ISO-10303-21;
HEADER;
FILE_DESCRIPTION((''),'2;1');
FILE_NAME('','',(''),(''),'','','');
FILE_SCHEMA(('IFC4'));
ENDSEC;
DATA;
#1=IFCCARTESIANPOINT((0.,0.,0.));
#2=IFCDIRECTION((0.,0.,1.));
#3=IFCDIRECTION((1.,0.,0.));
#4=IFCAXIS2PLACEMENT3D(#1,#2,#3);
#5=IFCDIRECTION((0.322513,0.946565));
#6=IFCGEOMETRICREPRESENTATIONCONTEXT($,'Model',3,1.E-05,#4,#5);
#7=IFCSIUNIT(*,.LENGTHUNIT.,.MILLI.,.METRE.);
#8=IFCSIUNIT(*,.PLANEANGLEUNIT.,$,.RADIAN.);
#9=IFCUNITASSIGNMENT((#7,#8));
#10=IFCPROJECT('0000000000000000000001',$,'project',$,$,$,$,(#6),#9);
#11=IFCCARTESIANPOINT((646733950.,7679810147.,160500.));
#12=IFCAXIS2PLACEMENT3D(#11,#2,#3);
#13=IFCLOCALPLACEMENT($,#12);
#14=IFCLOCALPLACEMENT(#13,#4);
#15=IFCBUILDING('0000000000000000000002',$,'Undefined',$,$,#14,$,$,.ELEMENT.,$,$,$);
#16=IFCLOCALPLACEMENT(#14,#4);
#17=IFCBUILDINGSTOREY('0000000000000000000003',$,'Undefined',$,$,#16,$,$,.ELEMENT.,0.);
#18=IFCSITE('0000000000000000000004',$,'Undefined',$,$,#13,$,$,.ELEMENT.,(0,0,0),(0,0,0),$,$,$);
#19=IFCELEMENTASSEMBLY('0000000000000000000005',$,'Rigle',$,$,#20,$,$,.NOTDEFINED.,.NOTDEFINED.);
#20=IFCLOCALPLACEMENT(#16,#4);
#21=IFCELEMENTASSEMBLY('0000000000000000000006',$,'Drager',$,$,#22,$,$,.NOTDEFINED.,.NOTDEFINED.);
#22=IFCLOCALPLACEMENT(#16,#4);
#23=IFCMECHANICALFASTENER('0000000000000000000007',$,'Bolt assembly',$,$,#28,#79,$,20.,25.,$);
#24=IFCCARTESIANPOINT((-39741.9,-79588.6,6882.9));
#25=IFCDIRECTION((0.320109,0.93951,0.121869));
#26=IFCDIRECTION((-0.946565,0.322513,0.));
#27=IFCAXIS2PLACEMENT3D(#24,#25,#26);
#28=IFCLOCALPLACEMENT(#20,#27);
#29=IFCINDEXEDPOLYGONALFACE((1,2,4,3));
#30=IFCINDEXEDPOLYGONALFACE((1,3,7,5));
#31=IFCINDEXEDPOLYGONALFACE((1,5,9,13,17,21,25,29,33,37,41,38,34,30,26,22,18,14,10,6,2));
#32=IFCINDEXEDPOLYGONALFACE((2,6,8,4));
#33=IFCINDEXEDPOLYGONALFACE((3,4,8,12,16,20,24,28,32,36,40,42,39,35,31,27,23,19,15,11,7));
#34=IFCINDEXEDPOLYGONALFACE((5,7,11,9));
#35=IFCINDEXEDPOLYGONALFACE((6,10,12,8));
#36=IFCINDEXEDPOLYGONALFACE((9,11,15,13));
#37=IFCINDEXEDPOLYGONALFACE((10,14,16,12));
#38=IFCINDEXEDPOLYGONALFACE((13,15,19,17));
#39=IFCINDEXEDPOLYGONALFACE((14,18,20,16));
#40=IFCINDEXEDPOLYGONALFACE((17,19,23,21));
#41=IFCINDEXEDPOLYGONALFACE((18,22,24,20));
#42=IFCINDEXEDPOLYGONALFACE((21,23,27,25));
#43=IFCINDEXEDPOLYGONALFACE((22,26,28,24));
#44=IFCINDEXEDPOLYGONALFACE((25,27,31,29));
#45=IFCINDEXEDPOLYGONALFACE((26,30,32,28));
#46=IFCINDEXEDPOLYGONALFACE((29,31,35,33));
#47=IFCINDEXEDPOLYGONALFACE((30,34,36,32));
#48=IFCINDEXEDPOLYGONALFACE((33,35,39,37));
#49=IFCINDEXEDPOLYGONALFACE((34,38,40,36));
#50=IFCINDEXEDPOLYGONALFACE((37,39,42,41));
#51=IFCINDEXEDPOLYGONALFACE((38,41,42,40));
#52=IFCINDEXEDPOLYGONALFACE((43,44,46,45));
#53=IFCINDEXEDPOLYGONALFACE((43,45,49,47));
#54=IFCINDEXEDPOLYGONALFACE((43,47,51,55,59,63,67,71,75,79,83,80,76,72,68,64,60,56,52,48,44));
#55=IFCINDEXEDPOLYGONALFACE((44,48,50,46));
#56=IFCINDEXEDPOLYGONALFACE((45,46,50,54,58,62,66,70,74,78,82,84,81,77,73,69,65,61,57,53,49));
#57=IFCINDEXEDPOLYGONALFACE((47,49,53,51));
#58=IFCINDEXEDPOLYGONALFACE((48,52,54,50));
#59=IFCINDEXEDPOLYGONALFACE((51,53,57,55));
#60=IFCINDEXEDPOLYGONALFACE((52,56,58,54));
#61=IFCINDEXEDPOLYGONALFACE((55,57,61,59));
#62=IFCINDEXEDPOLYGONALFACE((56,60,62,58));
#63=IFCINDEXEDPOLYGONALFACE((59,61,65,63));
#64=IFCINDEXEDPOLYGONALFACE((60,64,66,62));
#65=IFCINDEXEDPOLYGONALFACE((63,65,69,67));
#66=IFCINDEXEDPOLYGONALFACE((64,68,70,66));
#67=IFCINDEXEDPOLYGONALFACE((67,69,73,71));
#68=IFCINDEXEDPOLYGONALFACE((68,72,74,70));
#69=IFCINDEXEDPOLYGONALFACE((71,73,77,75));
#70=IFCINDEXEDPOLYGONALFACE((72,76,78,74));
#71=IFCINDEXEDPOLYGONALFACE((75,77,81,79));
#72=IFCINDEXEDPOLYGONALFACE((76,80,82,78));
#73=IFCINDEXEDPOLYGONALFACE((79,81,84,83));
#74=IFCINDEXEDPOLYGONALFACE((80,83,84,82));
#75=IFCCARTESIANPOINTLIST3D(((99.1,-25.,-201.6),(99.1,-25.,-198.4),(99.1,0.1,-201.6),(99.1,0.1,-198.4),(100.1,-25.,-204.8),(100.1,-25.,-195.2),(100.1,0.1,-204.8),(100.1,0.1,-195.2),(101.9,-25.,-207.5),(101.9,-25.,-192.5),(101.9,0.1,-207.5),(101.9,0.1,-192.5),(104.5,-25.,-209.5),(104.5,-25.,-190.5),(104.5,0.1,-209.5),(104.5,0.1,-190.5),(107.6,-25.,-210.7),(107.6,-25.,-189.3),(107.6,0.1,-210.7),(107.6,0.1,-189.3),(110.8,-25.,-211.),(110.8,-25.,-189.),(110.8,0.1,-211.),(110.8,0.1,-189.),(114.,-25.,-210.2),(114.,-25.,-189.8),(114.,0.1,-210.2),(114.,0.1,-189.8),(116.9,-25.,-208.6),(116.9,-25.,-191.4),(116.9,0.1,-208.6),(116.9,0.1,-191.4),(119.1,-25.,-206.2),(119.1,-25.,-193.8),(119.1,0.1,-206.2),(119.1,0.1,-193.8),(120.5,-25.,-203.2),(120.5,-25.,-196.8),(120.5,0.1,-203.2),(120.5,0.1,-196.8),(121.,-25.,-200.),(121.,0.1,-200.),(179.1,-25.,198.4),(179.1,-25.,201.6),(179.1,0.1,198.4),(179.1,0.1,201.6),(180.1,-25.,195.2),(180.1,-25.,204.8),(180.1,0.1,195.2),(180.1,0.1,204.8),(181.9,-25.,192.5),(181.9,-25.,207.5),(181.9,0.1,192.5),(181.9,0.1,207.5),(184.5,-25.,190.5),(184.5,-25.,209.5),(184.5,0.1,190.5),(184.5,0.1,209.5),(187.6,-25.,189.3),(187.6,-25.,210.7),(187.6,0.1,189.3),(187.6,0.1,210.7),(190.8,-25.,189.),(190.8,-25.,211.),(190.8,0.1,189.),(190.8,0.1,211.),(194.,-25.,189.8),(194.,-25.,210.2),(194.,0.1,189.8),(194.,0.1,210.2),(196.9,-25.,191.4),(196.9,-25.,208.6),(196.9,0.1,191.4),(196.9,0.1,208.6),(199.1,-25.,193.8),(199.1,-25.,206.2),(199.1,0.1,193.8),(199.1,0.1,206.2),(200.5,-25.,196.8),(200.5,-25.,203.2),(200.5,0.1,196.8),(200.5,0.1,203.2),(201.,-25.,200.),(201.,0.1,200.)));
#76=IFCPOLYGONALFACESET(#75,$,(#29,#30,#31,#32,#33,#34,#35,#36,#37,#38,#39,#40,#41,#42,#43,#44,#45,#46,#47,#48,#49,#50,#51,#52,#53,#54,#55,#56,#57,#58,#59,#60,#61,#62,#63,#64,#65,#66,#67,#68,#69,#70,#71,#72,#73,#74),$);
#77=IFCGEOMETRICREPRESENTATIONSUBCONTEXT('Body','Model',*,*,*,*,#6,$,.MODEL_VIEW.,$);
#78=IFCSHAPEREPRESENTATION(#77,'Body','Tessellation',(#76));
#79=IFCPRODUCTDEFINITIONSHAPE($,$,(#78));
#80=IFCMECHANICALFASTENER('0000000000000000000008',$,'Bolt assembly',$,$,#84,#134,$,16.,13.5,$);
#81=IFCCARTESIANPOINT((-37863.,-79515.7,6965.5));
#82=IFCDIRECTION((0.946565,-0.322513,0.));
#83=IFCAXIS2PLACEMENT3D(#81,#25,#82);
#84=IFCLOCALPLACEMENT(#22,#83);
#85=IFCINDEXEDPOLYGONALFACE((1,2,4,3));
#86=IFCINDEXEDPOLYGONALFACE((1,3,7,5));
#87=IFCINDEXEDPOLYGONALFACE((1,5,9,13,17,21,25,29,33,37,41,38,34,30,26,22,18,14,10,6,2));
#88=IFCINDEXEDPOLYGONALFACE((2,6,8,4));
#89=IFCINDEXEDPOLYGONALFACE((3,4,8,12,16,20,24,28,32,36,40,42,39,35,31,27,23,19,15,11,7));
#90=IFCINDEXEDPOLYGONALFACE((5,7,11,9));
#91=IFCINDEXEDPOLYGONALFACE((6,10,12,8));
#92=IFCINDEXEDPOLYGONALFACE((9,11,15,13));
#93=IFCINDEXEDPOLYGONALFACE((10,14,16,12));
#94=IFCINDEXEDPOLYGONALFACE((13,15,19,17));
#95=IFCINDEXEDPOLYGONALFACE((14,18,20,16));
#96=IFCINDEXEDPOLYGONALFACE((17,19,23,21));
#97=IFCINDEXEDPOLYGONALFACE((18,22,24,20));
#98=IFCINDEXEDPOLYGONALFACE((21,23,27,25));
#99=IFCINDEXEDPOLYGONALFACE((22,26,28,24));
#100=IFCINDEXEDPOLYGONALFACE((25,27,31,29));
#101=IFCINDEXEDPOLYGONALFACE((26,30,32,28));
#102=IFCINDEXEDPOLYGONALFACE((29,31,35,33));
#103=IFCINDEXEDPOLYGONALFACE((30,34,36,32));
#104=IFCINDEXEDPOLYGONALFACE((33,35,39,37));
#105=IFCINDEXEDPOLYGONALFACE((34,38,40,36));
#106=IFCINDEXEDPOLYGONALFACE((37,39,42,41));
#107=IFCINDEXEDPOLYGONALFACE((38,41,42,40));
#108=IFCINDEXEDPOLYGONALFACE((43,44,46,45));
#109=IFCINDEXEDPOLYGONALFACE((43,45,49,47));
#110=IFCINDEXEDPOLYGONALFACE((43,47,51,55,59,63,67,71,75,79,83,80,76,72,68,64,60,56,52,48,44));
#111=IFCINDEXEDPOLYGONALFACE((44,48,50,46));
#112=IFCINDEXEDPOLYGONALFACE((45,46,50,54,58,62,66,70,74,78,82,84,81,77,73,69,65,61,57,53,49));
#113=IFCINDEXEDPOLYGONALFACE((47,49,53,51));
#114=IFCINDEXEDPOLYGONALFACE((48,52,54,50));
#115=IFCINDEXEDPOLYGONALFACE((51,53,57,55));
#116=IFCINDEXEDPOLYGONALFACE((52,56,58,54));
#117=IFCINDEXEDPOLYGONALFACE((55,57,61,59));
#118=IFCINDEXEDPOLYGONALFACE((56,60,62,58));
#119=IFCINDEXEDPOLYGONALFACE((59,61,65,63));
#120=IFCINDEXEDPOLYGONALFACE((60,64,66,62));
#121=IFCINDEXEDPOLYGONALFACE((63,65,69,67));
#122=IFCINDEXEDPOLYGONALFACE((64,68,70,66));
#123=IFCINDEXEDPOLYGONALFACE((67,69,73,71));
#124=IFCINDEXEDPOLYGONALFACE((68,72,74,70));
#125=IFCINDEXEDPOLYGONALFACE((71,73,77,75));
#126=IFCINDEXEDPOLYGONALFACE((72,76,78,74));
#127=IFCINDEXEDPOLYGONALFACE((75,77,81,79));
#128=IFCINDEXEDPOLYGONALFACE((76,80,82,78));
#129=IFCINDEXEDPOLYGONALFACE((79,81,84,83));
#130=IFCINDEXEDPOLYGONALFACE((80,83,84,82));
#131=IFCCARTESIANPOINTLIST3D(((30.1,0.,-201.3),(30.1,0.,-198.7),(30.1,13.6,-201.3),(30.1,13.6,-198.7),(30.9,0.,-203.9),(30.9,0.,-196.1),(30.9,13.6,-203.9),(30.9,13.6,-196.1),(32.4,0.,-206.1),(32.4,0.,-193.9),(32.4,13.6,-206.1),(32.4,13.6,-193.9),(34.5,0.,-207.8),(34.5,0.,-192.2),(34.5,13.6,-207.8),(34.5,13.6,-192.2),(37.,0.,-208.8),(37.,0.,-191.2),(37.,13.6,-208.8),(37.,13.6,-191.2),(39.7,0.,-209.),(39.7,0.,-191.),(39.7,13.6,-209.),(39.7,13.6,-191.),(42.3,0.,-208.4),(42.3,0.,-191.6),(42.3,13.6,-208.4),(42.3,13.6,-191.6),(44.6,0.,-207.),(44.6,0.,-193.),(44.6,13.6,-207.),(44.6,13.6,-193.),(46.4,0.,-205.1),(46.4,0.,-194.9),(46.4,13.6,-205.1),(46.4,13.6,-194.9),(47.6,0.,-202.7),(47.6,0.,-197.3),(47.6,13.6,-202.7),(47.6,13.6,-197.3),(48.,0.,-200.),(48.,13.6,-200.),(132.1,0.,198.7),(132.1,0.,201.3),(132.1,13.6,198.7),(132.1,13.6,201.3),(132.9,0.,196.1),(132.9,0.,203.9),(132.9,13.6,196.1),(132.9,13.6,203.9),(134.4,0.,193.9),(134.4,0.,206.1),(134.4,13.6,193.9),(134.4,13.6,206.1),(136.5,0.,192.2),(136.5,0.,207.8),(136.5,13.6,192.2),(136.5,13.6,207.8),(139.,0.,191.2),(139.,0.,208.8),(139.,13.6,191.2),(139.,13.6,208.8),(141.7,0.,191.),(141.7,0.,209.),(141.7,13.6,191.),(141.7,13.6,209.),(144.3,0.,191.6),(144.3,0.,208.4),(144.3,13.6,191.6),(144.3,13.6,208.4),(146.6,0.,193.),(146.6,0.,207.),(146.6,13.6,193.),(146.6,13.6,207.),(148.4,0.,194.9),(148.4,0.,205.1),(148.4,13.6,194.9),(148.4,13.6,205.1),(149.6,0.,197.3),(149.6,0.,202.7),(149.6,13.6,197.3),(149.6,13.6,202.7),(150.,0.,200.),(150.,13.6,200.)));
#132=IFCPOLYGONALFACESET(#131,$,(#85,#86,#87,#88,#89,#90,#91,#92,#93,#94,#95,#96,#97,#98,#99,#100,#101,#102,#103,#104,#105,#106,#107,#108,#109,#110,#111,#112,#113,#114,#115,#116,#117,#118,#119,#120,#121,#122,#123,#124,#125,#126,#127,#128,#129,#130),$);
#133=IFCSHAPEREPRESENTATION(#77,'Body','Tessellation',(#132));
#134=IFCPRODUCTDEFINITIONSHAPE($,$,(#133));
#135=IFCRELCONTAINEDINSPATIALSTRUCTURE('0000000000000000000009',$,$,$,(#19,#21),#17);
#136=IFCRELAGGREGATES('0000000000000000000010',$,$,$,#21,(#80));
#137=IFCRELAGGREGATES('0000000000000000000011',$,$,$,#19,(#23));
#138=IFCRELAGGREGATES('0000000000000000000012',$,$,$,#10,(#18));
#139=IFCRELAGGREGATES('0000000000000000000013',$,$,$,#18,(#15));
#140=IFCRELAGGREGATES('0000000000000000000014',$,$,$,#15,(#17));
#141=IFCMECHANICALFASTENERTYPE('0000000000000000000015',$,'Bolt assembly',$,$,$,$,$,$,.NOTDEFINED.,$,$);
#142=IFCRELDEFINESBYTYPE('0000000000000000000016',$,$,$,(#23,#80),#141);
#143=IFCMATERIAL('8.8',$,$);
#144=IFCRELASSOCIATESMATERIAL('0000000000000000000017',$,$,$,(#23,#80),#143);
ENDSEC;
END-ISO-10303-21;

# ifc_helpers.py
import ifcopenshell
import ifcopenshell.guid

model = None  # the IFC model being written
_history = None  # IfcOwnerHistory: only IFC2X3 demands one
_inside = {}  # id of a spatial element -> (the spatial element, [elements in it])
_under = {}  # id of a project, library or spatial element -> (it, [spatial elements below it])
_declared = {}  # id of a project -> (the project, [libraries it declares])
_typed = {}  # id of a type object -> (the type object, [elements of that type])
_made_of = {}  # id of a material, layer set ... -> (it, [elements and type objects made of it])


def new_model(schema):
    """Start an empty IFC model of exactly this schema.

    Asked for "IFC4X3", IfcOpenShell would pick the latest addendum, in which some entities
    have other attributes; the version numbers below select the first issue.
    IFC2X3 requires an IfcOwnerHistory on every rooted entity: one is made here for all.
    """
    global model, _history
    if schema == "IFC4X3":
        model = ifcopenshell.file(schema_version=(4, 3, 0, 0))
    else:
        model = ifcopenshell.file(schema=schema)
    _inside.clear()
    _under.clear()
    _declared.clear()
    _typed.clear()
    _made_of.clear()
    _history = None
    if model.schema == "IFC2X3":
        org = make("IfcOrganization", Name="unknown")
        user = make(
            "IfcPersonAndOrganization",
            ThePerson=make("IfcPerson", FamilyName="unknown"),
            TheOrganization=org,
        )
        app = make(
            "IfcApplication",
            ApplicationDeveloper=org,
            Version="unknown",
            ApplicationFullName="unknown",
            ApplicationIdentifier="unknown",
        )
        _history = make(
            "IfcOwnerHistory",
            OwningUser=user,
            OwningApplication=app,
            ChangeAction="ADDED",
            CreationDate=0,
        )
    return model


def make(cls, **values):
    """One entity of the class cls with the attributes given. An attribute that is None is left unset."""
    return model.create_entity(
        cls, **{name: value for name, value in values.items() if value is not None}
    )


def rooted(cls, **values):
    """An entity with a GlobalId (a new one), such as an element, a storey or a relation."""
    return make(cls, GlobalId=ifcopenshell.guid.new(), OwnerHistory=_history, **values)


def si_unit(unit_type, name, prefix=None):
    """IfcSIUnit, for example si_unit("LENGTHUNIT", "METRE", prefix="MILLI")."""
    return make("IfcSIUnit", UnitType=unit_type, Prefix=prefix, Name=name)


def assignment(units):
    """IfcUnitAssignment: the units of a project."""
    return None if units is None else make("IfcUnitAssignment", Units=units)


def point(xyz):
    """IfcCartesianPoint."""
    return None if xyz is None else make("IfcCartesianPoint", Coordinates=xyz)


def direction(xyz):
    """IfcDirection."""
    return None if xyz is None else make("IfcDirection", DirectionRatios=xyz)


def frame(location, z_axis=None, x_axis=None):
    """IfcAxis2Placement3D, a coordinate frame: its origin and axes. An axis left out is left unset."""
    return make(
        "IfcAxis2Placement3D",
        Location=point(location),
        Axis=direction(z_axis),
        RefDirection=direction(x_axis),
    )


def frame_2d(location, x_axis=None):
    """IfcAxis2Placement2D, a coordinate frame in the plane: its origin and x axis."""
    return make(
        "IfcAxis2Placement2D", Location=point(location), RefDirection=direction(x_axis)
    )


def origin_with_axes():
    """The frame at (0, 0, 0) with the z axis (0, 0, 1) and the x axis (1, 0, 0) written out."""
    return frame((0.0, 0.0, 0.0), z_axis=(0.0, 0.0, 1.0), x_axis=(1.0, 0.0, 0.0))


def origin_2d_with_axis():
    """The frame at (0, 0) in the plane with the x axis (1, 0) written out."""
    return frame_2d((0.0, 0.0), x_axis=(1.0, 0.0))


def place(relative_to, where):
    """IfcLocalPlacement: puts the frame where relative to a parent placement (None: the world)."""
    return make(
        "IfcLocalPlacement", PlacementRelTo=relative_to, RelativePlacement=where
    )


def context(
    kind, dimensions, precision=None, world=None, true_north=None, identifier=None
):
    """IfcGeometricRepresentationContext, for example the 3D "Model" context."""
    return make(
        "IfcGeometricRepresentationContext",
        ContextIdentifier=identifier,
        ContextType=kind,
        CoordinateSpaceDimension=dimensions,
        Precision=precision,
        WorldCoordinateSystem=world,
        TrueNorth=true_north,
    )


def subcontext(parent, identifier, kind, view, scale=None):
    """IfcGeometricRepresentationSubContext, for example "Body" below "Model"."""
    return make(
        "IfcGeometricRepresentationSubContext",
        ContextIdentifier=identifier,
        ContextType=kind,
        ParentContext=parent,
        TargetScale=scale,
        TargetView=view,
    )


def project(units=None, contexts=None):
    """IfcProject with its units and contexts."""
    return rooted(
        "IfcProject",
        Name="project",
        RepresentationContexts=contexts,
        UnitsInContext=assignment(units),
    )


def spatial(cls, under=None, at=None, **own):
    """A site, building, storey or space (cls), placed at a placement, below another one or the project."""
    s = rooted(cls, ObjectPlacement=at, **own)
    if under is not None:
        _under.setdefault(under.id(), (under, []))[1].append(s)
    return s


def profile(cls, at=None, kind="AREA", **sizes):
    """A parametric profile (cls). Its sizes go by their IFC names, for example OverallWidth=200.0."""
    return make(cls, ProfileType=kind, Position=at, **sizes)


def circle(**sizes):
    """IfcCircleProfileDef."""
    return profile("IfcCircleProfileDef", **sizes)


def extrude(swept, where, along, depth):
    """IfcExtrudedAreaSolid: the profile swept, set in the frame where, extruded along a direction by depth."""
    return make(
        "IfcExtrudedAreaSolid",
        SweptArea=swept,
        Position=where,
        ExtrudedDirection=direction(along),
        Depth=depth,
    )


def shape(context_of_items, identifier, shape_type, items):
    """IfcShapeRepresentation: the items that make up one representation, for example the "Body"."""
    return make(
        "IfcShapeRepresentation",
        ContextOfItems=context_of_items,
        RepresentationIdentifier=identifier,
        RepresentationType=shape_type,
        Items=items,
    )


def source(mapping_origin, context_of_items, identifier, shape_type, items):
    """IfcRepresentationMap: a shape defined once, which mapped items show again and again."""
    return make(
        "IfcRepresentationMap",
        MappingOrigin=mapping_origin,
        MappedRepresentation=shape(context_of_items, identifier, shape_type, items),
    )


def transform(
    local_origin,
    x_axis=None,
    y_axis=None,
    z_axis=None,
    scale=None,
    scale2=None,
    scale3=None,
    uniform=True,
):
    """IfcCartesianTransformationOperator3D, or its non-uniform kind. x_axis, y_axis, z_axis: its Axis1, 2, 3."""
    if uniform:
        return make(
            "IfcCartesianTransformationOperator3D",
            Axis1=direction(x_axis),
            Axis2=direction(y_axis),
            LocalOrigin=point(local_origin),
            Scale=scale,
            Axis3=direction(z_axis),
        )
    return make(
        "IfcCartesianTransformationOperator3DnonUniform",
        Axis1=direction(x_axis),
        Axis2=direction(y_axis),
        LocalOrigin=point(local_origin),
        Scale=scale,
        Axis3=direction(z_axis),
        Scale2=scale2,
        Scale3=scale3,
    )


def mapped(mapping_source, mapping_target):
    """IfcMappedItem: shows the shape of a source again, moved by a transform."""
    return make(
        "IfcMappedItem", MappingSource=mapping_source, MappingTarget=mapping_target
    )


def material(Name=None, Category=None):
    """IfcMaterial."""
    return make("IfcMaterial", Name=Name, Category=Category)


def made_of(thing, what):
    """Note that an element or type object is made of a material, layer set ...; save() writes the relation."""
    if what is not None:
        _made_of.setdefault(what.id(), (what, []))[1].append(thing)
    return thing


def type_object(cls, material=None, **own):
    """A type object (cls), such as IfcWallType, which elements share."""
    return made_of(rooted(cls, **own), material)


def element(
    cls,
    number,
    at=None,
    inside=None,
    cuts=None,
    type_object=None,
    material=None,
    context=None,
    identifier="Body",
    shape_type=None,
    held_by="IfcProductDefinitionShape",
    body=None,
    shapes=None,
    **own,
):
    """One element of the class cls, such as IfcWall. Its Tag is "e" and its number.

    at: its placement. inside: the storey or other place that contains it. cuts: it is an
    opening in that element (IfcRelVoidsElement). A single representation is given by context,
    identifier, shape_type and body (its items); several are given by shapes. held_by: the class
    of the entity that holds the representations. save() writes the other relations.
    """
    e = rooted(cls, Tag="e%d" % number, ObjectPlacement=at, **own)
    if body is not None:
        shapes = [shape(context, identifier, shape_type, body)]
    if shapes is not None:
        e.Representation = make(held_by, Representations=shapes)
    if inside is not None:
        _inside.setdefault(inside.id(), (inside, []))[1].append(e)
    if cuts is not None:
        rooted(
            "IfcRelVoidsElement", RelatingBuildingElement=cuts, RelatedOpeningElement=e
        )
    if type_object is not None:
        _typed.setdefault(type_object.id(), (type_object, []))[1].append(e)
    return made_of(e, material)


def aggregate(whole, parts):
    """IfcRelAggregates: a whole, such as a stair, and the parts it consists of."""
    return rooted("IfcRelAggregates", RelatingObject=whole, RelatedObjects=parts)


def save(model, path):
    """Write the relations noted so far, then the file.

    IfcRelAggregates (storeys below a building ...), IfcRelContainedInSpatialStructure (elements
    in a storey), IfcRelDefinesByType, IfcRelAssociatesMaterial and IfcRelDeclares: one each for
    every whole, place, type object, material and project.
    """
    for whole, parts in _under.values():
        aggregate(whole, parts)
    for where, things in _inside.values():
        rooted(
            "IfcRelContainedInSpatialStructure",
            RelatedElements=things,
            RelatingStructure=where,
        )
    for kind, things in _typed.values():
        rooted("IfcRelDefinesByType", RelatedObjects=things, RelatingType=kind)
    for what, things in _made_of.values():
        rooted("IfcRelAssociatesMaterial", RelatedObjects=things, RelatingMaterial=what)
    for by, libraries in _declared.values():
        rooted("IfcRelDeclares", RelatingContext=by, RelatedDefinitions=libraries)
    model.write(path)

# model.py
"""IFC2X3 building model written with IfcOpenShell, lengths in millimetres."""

from ifc_helpers import new_model, si_unit, direction, frame, origin_with_axes, origin_2d_with_axis, place, context, subcontext, project, spatial, circle, extrude, source, transform, mapped, material, type_object, element, aggregate, save


model = new_model("IFC2X3")

# Units and contexts
model_context = context("Model", 3, precision=1e-05, world=origin_with_axes(), true_north=direction((0.322513, 0.946565)))
body_context = subcontext(model_context, "Body", "Model", "MODEL_VIEW")
ifc_project = project(units=[si_unit("LENGTHUNIT", "METRE", prefix="MILLI"), si_unit("PLANEANGLEUNIT", "RADIAN")], contexts=[model_context])

# Site, building, storey
site_placement = place(None, frame((646733950.0, 7679810147.0, 160500.0), z_axis=(0.0, 0.0, 1.0), x_axis=(1.0, 0.0, 0.0)))
site = spatial("IfcSite", under=ifc_project, at=site_placement, Name="Undefined", CompositionType="ELEMENT", RefLatitude=(0, 0, 0), RefLongitude=(0, 0, 0))
building_placement = place(site_placement, origin_with_axes())
building = spatial("IfcBuilding", under=site, at=building_placement, Name="Undefined", CompositionType="ELEMENT")
storey_placement = place(building_placement, origin_with_axes())
storey = spatial("IfcBuildingStorey", under=building, at=storey_placement, Name="Undefined", CompositionType="ELEMENT", Elevation=0.0)

# Element assembly
assembly_1_placement = place(storey_placement, origin_with_axes())
assembly_1 = element("IfcElementAssembly", 1, at=assembly_1_placement, inside=storey, Name="Rigle", AssemblyPlace="NOTDEFINED", PredefinedType="NOTDEFINED")

# Element assembly
assembly_2_placement = place(storey_placement, origin_with_axes())
assembly_2 = element("IfcElementAssembly", 2, at=assembly_2_placement, inside=storey, Name="Drager", AssemblyPlace="NOTDEFINED", PredefinedType="NOTDEFINED")

# Mechanical fasteners
mechanical_fastener_type = type_object("IfcMechanicalFastenerType", Name="Bolt assembly")
ifc_material_1 = material(Name="8.8")
shared_shape_1 = source(origin_with_axes(), body_context, "Body", "SweptSolid", [
    extrude(circle(Radius=11.0, at=origin_2d_with_axis()), frame((0.0, -25.0, 0.0), z_axis=(0.0, 1.0, 0.0), x_axis=(1.0, 0.0, 0.0)), (0.0, 0.0, 1.0), 25.1),
])
mechanical_fastener_1_placement = place(assembly_1_placement, frame((-39741.9, -79588.6, 6882.9), z_axis=(0.320109, 0.93951, 0.121869), x_axis=(-0.946565, 0.322513, 0.0)))
mechanical_fastener_1 = element("IfcMechanicalFastener", 3, at=mechanical_fastener_1_placement, type_object=mechanical_fastener_type, material=ifc_material_1, Name="Bolt assembly", NominalDiameter=20.0, NominalLength=25.0, context=body_context, shape_type="MappedRepresentation", body=[
    mapped(shared_shape_1, transform((110.0, 0.0, -200.0))),
    mapped(shared_shape_1, transform((190.0, 0.0, 200.0))),
])
shared_shape_2 = source(origin_with_axes(), body_context, "Body", "SweptSolid", [
    extrude(circle(Radius=9.0, at=origin_2d_with_axis()), frame((0.0, 0.0, 0.0), z_axis=(0.0, 1.0, 0.0), x_axis=(1.0, 0.0, 0.0)), (0.0, 0.0, 1.0), 13.6),
])
mechanical_fastener_2_placement = place(assembly_2_placement, frame((-37863.0, -79515.7, 6965.5), z_axis=(0.320109, 0.93951, 0.121869), x_axis=(0.946565, -0.322513, 0.0)))
mechanical_fastener_2 = element("IfcMechanicalFastener", 4, at=mechanical_fastener_2_placement, type_object=mechanical_fastener_type, material=ifc_material_1, Name="Bolt assembly", NominalDiameter=16.0, NominalLength=13.5, context=body_context, shape_type="MappedRepresentation", body=[
    mapped(shared_shape_2, transform((39.0, 0.0, -200.0))),
    mapped(shared_shape_2, transform((141.0, 0.0, 200.0))),
])
aggregate(assembly_2, [mechanical_fastener_2])
aggregate(assembly_1, [mechanical_fastener_1])

save(model, "model.ifc")
